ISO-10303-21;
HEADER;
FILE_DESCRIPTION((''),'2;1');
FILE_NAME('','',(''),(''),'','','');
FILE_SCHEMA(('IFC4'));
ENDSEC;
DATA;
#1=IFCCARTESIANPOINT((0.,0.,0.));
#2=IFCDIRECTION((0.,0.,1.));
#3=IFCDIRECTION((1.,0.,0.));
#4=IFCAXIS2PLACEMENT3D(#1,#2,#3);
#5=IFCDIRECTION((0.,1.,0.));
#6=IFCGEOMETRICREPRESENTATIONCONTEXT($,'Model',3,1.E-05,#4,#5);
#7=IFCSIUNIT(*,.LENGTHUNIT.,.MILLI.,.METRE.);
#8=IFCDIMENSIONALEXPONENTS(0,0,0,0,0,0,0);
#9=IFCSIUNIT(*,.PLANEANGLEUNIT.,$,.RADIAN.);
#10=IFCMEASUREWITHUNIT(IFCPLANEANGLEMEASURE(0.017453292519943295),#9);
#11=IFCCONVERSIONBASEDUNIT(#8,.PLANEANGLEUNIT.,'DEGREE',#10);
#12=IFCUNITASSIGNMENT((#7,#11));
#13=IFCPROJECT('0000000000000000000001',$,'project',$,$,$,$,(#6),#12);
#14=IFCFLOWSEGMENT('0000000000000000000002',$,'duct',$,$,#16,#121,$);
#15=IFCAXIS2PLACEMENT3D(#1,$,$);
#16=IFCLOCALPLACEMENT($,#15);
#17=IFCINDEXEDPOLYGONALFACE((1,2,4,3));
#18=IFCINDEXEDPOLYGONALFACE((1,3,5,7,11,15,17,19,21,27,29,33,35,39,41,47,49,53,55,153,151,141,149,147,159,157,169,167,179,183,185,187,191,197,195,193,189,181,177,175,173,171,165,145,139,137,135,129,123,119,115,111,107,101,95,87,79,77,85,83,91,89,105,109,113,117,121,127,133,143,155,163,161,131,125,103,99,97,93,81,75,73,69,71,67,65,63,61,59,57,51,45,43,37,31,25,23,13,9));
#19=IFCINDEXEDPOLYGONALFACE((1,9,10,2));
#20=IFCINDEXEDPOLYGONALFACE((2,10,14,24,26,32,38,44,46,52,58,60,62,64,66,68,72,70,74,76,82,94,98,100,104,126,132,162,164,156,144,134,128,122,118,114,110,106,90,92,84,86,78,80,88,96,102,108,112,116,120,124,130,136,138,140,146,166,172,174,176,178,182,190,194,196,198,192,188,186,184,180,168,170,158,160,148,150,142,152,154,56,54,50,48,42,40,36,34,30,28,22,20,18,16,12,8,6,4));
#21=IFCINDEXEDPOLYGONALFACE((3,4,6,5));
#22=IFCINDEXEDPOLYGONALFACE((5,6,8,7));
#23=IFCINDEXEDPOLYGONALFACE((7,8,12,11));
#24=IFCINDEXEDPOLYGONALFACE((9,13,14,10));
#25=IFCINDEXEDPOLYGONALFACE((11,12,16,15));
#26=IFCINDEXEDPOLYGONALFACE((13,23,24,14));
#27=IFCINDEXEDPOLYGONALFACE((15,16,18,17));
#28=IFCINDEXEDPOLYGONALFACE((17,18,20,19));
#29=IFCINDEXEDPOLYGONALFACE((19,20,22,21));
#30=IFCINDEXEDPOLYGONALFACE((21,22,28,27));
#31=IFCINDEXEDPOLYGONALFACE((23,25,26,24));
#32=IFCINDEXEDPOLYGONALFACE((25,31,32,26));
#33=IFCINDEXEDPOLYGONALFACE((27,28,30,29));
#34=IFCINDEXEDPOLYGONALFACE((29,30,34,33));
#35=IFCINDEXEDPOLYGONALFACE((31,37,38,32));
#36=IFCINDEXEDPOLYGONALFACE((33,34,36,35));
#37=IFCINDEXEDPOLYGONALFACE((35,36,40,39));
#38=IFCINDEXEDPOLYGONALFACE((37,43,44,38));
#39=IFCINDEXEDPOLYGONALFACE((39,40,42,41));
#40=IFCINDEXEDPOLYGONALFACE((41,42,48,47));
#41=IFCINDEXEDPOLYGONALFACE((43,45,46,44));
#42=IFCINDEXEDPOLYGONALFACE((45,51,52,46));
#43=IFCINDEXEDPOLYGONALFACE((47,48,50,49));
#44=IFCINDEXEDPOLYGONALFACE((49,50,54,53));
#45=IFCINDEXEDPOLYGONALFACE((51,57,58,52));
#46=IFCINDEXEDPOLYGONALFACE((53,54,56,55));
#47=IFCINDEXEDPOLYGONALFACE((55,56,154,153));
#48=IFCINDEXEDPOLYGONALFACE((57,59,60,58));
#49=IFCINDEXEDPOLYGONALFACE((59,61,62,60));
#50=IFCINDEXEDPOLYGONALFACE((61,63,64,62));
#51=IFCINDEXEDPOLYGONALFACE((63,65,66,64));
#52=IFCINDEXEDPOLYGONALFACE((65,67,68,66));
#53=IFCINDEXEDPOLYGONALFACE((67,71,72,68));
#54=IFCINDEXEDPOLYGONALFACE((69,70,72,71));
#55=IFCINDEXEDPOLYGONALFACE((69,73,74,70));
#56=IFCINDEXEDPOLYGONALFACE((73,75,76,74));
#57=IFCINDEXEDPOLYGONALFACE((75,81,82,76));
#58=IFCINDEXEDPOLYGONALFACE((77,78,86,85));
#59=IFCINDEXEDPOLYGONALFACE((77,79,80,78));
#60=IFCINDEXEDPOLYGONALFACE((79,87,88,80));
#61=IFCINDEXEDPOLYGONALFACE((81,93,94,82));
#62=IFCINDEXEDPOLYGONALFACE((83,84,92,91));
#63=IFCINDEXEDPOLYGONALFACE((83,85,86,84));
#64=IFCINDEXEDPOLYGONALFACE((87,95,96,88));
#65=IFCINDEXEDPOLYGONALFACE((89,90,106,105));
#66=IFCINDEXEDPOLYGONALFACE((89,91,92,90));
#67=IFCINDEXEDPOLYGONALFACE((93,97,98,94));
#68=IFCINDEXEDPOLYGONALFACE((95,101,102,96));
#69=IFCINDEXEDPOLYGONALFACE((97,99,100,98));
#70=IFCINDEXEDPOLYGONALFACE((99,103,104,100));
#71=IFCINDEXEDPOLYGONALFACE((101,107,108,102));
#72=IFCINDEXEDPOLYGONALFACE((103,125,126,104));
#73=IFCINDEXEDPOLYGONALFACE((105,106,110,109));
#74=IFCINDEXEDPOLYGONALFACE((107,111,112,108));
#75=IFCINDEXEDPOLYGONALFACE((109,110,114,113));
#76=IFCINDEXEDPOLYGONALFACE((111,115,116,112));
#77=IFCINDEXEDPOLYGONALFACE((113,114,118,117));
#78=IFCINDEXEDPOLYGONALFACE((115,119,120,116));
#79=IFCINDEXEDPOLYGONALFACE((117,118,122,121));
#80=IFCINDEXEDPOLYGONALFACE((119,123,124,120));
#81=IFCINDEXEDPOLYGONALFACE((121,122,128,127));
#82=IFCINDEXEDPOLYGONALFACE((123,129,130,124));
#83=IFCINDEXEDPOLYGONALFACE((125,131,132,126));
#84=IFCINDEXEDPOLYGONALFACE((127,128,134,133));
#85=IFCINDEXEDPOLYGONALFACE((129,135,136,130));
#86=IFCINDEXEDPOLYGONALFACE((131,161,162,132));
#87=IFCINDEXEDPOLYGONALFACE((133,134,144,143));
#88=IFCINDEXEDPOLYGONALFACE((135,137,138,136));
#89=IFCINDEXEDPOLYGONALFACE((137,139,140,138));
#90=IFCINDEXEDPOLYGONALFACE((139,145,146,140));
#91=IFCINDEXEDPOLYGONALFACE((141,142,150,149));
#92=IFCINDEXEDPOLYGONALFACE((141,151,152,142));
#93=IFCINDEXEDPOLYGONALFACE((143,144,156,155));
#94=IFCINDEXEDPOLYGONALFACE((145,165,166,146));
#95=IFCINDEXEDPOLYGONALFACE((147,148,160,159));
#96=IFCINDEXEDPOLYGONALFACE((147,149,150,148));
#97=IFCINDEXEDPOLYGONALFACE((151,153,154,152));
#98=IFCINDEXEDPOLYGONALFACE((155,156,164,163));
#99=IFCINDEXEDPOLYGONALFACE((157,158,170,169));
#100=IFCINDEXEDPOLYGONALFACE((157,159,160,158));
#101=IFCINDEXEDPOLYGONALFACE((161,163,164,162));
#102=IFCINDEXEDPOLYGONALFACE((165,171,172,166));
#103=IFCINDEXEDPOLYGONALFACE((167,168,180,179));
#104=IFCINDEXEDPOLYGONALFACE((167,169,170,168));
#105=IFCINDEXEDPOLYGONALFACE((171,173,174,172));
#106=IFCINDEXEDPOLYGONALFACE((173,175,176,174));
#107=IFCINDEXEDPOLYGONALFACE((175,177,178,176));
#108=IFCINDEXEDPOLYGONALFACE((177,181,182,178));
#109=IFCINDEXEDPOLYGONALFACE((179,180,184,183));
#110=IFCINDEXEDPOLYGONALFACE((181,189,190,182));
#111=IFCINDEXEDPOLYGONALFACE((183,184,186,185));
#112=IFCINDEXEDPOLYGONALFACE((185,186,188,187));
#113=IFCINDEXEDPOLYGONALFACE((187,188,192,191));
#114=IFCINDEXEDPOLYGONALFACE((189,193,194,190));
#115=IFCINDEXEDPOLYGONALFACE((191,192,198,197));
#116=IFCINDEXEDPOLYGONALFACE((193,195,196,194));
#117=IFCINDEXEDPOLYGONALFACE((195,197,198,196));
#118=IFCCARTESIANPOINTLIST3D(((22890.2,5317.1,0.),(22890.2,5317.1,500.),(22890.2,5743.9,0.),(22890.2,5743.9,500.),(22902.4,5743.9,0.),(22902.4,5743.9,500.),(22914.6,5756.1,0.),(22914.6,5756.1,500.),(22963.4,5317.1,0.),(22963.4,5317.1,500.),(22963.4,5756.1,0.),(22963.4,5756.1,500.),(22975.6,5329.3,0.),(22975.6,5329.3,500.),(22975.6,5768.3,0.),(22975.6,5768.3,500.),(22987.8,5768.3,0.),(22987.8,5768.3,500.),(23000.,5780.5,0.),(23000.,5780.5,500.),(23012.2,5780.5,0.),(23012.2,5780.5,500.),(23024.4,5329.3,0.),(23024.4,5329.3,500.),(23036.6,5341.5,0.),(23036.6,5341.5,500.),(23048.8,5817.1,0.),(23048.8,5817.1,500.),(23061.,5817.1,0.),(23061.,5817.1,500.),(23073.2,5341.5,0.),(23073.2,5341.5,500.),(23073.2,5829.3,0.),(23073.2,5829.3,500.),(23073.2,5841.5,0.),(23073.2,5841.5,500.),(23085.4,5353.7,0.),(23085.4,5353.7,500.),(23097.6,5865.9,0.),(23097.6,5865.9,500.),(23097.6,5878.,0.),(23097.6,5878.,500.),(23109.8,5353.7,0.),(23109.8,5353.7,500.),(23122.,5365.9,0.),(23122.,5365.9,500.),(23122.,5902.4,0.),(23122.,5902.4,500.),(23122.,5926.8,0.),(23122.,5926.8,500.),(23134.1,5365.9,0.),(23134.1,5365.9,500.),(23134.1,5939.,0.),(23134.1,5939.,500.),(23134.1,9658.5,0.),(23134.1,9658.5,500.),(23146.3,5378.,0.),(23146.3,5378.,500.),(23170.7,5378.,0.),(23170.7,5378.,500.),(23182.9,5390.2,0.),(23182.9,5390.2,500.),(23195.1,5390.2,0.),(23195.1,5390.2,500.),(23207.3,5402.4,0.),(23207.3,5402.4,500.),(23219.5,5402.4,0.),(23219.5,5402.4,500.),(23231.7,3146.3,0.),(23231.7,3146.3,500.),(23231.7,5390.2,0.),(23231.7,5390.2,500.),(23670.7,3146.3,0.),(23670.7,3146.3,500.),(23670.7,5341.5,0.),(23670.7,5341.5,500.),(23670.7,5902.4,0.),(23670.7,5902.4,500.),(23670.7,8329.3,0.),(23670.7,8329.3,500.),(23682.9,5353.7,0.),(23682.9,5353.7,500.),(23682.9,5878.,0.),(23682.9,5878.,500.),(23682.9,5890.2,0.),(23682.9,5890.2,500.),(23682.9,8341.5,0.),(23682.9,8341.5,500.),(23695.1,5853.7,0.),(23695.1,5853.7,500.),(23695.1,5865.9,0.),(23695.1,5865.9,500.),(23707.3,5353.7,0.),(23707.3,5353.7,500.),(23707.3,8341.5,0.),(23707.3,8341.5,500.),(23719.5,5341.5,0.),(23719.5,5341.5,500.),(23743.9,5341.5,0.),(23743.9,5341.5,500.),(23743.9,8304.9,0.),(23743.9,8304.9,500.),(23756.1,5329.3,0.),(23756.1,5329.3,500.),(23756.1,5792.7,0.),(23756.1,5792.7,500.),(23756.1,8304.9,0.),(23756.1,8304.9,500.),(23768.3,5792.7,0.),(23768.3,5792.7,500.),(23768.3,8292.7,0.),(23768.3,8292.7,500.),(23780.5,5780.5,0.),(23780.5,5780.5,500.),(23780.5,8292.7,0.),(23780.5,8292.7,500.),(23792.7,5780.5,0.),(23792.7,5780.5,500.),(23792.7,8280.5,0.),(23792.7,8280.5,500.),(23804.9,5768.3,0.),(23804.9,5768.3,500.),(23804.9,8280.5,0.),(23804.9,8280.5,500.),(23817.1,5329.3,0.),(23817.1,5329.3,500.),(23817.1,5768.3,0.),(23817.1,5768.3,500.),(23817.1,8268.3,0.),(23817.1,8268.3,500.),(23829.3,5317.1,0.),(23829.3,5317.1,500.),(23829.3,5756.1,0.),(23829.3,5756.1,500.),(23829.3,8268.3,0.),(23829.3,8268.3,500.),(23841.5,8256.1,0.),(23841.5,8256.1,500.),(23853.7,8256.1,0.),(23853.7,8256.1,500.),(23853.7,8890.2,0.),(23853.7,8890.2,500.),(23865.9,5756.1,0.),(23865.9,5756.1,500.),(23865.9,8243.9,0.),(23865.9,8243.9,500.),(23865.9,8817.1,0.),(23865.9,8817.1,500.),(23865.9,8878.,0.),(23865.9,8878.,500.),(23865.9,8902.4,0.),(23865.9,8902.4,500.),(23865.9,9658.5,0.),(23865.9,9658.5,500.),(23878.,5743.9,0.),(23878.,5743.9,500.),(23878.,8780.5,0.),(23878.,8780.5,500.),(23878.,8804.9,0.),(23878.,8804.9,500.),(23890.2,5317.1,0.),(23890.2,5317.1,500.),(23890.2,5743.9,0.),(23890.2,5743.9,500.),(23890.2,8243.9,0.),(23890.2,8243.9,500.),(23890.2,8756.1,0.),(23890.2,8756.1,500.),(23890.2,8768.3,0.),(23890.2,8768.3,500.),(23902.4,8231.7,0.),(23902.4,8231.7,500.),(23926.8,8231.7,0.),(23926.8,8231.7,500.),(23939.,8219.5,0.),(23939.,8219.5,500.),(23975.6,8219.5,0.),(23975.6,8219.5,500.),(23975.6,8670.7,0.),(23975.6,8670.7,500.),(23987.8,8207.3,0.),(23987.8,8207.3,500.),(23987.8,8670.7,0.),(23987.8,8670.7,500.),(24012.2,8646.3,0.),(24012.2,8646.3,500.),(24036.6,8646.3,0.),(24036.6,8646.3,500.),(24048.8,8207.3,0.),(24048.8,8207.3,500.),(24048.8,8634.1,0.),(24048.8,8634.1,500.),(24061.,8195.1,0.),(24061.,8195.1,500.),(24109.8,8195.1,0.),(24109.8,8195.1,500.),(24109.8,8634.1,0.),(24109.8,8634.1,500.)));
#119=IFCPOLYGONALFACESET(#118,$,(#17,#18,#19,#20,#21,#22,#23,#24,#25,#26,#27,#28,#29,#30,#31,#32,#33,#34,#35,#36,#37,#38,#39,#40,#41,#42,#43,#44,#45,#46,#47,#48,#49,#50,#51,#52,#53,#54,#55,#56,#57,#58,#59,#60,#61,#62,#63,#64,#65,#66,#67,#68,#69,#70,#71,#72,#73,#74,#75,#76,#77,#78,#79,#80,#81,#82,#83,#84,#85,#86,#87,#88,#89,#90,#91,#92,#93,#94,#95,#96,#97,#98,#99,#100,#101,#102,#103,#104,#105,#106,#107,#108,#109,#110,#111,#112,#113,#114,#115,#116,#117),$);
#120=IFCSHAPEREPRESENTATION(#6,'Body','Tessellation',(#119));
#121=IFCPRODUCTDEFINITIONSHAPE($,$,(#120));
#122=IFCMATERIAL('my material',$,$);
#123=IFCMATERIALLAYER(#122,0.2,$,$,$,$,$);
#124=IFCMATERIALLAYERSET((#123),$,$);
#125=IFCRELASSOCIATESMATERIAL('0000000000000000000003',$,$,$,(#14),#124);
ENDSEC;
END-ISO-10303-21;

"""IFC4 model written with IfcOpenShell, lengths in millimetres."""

from ifc_helpers import new_model, entity, si_unit, converted_unit, direction, origin_with_axes, place, context, project, polyline, outline, extrude, material, layer, layer_set, layer_usage, element, save


model = new_model("IFC4")

# Units and contexts
model_context = context("Model", 3, precision=1e-05, world=origin_with_axes(), true_north=direction((0.0, 1.0, 0.0)))
ifc_project = project(units=[si_unit("LENGTHUNIT", "METRE", prefix="MILLI"), converted_unit("PLANEANGLEUNIT", "DEGREE", entity("IfcPlaneAngleMeasure", 0.017453292519943295), si_unit("PLANEANGLEUNIT", "RADIAN"), dimensions=[0, 0, 0, 0, 0, 0, 0])], contexts=[model_context])

# Flow segment
ifc_material_1 = material(Name="my material")
ifc_layer_1 = layer(ifc_material_1, 0.2)
ifc_layer_set_1 = layer_set([ifc_layer_1])
ifc_layer_usage_1 = layer_usage(ifc_layer_set_1, "AXIS2", "POSITIVE", -0.1)
flow_segment_1_placement = place(None, origin_with_axes())
element("IfcFlowSegment", 1, at=flow_segment_1_placement, material=ifc_layer_usage_1, Name="duct", context=model_context, shape_type="SweptSolid", body=[
    extrude(outline(polyline([(22890.2, 5317.1), (22963.4, 5317.1), (22975.6, 5329.3), (23024.4, 5329.3), (23036.6, 5341.5), (23073.2, 5341.5), (23085.4, 5353.7), (23109.8, 5353.7), (23122.0, 5365.9), (23134.1, 5365.9), (23146.3, 5378.0), (23170.7, 5378.0), (23182.9, 5390.2), (23195.1, 5390.2), (23207.3, 5402.4), (23219.5, 5402.4), (23231.7, 5390.2), (23231.7, 3146.3), (23670.7, 3146.3), (23670.7, 5341.5), (23682.9, 5353.7), (23707.3, 5353.7), (23719.5, 5341.5), (23743.9, 5341.5), (23756.1, 5329.3), (23817.1, 5329.3), (23829.3, 5317.1), (23890.2, 5317.1), (23890.2, 5743.9), (23878.0, 5743.9), (23865.9, 5756.1), (23829.3, 5756.1), (23817.1, 5768.3), (23804.9, 5768.3), (23792.7, 5780.5), (23780.5, 5780.5), (23768.3, 5792.7), (23756.1, 5792.7), (23695.1, 5853.7), (23695.1, 5865.9), (23682.9, 5878.0), (23682.9, 5890.2), (23670.7, 5902.4), (23670.7, 8329.3), (23682.9, 8341.5), (23707.3, 8341.5), (23743.9, 8304.9), (23756.1, 8304.9), (23768.3, 8292.7), (23780.5, 8292.7), (23792.7, 8280.5), (23804.9, 8280.5), (23817.1, 8268.3), (23829.3, 8268.3), (23841.5, 8256.1), (23853.7, 8256.1), (23865.9, 8243.9), (23890.2, 8243.9), (23902.4, 8231.7), (23926.8, 8231.7), (23939.0, 8219.5), (23975.6, 8219.5), (23987.8, 8207.3), (24048.8, 8207.3), (24061.0, 8195.1), (24109.8, 8195.1), (24109.8, 8634.1), (24048.8, 8634.1), (24036.6, 8646.3), (24012.2, 8646.3), (23987.8, 8670.7), (23975.6, 8670.7), (23890.2, 8756.1), (23890.2, 8768.3), (23878.0, 8780.5), (23878.0, 8804.9), (23865.9, 8817.1), (23865.9, 8878.0), (23853.7, 8890.2), (23865.9, 8902.4), (23865.9, 9658.5), (23134.1, 9658.5), (23134.1, 5939.0), (23122.0, 5926.8), (23122.0, 5902.4), (23097.6, 5878.0), (23097.6, 5865.9), (23073.2, 5841.5), (23073.2, 5829.3), (23061.0, 5817.1), (23048.8, 5817.1), (23012.2, 5780.5), (23000.0, 5780.5), (22987.8, 5768.3), (22975.6, 5768.3), (22963.4, 5756.1), (22914.6, 5756.1), (22902.4, 5743.9), (22890.2, 5743.9), (22890.2, 5317.1)])), origin_with_axes(), (0.0, 0.0, 1.0), 500.0),
])

save(model, "model.ifc")
